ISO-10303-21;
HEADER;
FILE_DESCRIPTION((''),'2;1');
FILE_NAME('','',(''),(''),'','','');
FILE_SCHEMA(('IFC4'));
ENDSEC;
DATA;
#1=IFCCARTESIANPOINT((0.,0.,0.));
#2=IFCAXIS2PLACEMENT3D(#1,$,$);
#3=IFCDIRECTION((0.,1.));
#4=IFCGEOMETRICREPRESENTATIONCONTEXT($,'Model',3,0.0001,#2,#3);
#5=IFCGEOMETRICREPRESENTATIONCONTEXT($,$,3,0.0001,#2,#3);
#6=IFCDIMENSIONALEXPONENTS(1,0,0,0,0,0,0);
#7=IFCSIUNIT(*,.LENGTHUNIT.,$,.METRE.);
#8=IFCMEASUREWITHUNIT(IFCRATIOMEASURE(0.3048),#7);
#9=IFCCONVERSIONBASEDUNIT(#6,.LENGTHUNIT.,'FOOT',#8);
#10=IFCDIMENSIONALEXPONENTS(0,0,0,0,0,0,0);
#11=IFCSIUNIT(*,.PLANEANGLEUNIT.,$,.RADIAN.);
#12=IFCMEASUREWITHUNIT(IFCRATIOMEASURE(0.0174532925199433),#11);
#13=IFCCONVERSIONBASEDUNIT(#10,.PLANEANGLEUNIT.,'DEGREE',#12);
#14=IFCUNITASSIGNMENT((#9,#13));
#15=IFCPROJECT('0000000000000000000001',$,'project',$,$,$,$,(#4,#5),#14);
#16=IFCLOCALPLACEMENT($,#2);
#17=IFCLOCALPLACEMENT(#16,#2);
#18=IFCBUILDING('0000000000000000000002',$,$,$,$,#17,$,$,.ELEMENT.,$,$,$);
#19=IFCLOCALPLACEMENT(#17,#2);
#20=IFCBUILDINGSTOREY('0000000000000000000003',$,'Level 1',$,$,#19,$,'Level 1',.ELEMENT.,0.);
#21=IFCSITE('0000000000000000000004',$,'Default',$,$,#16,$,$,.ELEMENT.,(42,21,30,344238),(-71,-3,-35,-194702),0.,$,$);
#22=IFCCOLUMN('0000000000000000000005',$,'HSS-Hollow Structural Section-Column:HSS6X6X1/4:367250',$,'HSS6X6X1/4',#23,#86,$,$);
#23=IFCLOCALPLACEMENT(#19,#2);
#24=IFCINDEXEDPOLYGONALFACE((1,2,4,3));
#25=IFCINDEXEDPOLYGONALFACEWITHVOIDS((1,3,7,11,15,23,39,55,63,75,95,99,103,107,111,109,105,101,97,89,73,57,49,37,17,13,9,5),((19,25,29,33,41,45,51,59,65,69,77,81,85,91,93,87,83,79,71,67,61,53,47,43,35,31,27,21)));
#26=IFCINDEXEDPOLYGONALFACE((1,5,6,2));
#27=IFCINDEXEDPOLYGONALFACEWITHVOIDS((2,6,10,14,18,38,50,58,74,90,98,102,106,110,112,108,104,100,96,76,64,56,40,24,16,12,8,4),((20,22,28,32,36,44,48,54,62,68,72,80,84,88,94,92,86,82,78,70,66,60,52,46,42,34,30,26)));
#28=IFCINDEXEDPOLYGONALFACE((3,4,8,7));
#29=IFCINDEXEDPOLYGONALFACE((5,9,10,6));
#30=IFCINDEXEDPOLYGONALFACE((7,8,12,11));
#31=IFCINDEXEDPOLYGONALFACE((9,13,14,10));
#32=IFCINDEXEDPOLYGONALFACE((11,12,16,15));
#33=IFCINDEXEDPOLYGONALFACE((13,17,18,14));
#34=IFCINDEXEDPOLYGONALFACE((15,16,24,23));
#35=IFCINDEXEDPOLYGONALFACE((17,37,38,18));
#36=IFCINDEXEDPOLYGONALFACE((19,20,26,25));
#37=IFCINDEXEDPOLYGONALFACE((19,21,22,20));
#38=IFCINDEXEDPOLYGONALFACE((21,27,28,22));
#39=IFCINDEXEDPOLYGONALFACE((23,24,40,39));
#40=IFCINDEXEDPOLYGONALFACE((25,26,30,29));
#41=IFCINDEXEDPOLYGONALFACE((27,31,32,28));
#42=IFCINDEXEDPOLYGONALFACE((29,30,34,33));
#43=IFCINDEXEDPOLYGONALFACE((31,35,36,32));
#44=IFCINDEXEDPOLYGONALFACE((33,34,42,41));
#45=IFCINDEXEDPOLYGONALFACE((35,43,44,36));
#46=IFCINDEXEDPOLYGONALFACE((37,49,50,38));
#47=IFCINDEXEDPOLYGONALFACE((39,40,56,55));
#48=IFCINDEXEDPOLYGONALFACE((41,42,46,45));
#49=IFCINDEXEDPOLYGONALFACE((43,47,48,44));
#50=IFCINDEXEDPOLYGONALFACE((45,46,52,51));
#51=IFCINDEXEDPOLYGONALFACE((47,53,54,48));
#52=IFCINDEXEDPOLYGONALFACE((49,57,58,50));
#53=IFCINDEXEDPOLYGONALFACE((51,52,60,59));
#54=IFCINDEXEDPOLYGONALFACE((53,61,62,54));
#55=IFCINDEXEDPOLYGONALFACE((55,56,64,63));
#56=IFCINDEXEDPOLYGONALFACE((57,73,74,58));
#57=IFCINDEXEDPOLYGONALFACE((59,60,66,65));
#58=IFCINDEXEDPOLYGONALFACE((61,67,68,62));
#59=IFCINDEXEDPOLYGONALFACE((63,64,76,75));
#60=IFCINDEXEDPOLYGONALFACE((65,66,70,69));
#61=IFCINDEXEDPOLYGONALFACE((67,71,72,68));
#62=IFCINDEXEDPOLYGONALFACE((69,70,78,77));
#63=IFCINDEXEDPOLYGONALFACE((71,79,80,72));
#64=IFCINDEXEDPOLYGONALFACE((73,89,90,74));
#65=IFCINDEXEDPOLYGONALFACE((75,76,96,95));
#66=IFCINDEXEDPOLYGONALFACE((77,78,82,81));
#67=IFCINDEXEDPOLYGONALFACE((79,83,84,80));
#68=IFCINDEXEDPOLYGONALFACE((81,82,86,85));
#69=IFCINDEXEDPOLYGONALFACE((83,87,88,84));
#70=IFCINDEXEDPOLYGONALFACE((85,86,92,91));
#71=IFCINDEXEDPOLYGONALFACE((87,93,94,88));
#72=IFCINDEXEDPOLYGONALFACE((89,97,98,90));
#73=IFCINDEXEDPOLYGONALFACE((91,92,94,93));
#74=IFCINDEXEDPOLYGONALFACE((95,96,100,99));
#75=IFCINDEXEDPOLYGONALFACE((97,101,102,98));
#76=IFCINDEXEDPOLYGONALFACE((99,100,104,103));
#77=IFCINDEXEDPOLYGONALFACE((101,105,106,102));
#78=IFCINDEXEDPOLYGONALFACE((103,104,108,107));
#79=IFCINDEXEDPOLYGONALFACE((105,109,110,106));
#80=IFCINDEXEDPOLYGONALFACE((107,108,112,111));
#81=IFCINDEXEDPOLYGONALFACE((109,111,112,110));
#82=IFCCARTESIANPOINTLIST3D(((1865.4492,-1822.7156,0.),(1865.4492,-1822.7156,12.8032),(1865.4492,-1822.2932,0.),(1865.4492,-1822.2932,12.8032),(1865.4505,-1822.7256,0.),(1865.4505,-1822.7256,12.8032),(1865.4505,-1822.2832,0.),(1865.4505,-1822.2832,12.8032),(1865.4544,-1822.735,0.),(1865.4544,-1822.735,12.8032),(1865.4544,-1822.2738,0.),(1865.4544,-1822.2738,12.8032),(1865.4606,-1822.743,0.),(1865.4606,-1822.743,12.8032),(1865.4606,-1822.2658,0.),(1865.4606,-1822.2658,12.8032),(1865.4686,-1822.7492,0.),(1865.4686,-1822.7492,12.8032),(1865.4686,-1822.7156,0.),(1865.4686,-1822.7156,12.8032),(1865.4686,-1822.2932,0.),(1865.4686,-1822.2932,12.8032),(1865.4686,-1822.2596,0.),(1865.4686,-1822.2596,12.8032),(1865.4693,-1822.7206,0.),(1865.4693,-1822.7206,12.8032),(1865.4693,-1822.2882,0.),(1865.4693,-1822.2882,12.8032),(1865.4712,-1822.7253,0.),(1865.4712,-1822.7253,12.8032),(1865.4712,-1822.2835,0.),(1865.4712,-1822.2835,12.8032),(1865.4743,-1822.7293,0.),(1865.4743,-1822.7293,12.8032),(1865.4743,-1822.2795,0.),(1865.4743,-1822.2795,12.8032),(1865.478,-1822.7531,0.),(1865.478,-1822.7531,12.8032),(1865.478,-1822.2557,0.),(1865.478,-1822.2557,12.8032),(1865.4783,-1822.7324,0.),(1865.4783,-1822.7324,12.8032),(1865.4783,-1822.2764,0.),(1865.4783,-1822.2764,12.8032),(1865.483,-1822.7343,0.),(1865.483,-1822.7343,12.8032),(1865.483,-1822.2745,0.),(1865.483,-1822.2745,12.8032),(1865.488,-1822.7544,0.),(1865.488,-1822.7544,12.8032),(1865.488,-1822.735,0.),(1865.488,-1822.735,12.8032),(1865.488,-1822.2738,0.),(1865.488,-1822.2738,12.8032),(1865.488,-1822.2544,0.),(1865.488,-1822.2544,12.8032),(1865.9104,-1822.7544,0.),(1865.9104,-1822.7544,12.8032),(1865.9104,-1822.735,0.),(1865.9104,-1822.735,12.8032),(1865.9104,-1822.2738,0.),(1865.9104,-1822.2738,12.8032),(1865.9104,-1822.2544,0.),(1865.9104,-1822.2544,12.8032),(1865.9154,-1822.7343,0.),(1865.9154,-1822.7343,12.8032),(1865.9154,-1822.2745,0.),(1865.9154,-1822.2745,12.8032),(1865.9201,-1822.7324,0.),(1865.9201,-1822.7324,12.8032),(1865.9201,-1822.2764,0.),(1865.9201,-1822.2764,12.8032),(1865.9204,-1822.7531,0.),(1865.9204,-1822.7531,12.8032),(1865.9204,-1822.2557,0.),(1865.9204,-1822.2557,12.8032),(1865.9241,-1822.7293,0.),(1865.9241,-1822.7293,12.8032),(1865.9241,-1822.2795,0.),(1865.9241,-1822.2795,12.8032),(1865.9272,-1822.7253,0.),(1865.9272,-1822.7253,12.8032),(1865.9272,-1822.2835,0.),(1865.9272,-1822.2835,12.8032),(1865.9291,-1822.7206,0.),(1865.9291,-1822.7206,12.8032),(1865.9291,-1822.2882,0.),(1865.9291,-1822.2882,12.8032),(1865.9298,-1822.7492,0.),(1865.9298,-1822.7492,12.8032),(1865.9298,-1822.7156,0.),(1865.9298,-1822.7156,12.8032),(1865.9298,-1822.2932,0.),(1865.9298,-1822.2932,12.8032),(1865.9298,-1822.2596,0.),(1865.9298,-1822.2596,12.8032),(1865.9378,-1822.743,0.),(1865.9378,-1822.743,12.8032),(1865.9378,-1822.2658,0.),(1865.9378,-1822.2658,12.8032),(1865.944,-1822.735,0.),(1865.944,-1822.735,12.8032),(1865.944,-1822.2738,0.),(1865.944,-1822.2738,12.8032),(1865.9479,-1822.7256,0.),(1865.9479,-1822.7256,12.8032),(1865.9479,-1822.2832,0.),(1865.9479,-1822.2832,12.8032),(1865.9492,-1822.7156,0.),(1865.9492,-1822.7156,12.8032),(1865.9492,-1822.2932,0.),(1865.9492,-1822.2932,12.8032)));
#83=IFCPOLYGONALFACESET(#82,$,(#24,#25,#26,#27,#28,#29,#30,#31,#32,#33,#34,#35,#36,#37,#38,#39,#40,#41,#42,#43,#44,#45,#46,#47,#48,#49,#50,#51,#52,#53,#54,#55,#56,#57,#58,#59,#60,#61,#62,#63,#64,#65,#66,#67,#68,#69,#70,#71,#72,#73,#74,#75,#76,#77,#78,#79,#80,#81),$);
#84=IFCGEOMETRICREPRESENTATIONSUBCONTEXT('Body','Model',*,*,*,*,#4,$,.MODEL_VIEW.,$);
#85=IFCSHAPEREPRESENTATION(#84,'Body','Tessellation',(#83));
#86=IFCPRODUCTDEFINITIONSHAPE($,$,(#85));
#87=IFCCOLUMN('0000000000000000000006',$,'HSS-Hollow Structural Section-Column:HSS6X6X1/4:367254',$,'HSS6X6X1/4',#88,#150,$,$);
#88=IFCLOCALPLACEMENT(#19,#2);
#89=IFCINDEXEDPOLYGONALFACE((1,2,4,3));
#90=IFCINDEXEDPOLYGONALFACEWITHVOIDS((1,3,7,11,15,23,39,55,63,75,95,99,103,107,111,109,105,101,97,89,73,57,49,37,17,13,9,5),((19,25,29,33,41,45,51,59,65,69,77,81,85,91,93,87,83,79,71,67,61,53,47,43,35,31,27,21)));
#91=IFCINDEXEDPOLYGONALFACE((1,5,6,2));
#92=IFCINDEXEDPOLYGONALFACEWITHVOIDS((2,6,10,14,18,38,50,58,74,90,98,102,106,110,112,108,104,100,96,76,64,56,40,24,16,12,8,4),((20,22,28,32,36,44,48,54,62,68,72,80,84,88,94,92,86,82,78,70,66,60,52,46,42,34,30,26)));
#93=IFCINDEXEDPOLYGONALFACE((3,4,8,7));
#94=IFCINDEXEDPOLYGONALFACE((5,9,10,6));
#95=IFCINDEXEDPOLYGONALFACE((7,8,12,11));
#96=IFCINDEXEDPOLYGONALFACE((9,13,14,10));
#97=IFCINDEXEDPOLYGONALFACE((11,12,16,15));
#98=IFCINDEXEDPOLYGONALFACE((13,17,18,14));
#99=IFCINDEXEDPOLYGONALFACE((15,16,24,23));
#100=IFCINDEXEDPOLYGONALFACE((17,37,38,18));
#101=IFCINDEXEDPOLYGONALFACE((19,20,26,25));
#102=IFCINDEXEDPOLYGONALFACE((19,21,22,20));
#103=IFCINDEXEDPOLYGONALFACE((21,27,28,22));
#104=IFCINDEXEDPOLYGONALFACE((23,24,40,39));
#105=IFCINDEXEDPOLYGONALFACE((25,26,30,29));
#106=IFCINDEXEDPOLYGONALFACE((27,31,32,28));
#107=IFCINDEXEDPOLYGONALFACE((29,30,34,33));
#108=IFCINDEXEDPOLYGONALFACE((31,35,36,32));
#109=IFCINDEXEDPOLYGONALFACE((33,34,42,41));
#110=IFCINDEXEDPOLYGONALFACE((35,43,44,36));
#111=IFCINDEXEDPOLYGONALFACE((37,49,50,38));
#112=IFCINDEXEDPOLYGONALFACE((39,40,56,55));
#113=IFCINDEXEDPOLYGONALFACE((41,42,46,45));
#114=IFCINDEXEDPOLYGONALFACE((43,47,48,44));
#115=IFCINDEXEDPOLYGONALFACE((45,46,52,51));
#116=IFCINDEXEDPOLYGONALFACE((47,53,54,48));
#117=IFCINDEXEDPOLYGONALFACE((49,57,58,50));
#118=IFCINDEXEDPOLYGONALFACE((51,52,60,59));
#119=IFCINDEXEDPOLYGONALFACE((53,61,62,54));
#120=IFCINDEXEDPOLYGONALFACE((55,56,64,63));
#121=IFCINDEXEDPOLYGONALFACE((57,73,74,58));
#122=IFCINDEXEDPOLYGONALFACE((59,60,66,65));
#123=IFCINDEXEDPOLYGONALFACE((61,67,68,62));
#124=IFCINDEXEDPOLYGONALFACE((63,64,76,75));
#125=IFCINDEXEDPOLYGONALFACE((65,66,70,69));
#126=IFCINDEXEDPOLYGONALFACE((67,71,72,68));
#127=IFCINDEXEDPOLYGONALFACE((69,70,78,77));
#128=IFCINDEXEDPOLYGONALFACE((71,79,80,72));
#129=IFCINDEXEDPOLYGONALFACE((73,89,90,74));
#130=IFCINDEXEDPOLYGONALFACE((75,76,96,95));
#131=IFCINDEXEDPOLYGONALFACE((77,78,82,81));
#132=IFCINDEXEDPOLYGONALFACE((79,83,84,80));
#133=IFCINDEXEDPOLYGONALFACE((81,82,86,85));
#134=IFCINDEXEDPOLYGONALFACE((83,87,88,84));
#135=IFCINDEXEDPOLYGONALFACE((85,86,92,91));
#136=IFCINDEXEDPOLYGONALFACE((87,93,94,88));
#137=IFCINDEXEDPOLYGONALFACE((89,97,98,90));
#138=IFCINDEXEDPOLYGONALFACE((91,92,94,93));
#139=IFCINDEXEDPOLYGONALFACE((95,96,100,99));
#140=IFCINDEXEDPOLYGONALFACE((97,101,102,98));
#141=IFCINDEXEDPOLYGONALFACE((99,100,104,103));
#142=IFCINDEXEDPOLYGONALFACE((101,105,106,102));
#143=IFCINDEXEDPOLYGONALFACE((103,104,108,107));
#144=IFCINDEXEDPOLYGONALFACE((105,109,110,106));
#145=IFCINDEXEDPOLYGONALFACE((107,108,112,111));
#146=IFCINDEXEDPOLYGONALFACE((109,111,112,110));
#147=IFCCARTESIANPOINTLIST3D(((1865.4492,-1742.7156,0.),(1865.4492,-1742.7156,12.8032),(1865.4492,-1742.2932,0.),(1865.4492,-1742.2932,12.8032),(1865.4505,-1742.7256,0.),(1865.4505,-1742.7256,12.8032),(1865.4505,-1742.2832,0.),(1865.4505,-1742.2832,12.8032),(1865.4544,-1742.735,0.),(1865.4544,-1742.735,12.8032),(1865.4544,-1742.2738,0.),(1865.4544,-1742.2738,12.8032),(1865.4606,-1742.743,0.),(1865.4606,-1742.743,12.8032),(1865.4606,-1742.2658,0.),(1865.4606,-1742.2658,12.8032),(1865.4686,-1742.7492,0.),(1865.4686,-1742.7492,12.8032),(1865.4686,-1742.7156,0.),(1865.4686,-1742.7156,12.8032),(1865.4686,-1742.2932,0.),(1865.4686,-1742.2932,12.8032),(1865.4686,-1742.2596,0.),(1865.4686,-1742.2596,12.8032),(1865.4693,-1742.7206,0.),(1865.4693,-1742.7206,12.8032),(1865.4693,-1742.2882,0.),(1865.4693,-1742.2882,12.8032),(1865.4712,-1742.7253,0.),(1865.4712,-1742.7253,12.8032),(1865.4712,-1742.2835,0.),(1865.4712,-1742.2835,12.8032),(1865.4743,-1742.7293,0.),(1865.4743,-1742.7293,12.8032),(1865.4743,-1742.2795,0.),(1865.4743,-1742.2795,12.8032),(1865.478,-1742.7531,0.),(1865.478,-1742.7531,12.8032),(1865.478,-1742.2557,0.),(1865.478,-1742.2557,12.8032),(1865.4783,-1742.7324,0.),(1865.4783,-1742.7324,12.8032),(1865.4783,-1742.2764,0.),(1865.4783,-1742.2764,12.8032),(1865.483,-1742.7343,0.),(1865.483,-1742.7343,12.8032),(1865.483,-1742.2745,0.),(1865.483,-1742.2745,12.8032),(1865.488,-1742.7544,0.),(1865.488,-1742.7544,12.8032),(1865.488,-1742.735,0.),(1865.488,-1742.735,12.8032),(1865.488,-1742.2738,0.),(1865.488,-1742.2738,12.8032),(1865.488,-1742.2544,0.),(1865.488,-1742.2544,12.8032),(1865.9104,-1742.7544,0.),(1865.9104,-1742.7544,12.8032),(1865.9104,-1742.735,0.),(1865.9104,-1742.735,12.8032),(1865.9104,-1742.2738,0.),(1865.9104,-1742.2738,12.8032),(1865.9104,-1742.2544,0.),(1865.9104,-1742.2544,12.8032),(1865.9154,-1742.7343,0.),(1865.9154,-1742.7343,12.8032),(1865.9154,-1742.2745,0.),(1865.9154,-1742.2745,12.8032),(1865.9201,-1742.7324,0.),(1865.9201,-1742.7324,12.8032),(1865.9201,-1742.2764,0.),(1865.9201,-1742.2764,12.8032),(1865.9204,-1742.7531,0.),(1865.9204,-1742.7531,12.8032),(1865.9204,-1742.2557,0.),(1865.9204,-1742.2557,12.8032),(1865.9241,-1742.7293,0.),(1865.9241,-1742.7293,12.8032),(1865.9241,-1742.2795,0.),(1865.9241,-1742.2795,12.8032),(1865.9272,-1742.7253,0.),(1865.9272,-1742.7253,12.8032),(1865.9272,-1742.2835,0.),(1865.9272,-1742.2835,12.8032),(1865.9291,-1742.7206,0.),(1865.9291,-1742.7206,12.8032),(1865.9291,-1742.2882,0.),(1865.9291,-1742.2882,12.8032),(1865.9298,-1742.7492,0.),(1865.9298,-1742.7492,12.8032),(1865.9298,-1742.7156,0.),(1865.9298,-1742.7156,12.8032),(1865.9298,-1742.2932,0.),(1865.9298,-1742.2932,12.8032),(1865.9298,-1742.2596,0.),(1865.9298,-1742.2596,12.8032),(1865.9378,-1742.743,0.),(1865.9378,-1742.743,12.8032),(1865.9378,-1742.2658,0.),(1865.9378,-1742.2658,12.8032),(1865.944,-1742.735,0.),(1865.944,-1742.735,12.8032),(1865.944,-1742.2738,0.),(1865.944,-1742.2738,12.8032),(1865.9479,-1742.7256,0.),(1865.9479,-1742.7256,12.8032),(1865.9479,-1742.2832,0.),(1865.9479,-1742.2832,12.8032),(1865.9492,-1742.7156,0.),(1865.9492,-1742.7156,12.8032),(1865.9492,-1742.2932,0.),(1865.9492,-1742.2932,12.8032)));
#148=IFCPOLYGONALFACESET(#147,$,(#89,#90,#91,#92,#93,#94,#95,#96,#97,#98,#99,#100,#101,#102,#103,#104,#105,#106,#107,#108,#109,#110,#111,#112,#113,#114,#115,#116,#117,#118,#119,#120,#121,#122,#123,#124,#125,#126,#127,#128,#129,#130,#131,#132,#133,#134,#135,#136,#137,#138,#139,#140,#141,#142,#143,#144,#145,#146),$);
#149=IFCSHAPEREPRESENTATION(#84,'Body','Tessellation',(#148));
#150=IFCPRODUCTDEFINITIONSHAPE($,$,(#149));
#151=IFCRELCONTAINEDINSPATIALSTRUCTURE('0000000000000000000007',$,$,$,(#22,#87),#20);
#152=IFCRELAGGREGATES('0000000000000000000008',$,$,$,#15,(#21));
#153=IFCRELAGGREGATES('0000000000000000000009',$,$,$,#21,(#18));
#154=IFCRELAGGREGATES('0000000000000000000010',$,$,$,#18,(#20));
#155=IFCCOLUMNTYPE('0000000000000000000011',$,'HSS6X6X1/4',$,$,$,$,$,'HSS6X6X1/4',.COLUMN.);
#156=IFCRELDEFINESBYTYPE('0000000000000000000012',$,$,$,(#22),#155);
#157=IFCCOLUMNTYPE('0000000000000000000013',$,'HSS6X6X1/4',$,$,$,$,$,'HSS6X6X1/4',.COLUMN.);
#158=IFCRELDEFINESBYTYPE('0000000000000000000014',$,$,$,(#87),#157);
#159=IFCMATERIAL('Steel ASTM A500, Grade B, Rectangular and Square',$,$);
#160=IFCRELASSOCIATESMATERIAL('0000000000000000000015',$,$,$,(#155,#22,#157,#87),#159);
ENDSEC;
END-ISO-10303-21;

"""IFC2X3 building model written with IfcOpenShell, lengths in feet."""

from ifc_helpers import new_model, entity, si_unit, converted_unit, direction, frame, frame_2d, origin, place, context, subcontext, project, spatial, polyline, circle_curve, parameter, trimmed, segment, composite_curve, outline, extrude, source, transform, mapped, material, type_object, type_shapes, element, save


model = new_model("IFC2X3")

# Units and contexts
model_context = context("Model", 3, precision=0.0001, world=origin(), true_north=direction((0.0, 1.0)))
context_of_model = context(None, 3, precision=0.0001, world=origin(), true_north=direction((0.0, 1.0)))
body_context = subcontext(model_context, "Body", "Model", "MODEL_VIEW")
ifc_project = project(units=[converted_unit("LENGTHUNIT", "FOOT", entity("IfcRatioMeasure", 0.3048), si_unit("LENGTHUNIT", "METRE"), dimensions=[1, 0, 0, 0, 0, 0, 0]), converted_unit("PLANEANGLEUNIT", "DEGREE", entity("IfcRatioMeasure", 0.0174532925199433), si_unit("PLANEANGLEUNIT", "RADIAN"), dimensions=[0, 0, 0, 0, 0, 0, 0])], contexts=[model_context, context_of_model])

# Site, building, storey
site_placement = place(None, origin())
site = spatial("IfcSite", under=ifc_project, at=site_placement, Name="Default", CompositionType="ELEMENT", RefLatitude=(42, 21, 30, 344238), RefLongitude=(-71, -3, -35, -194702), RefElevation=0.0)
building_placement = place(site_placement, origin())
building = spatial("IfcBuilding", under=site, at=building_placement, CompositionType="ELEMENT")
storey_placement = place(building_placement, origin())
storey = spatial("IfcBuildingStorey", under=building, at=storey_placement, Name="Level 1", LongName="Level 1", CompositionType="ELEMENT", Elevation=0.0)

# Columns
ifc_material_1 = material(Name="Steel ASTM A500, Grade B, Rectangular and Square")
column_type_1 = type_object("IfcColumnType", Name="HSS6X6X1/4", ElementType="HSS6X6X1/4", PredefinedType="COLUMN", material=ifc_material_1)
shared_shape_1 = source(origin(), body_context, "Body", "SweptSolid", [
    extrude(outline(composite_curve([segment(polyline([(-0.2112, -0.25), (0.2112, -0.25)]), True, "CONTINUOUS"), segment(trimmed(circle_curve(frame_2d((0.2112, -0.2112), x_axis=(-1.0, 0.0)), 0.0388), [parameter(90.0)], [parameter(180.0)], True, "PARAMETER"), True, "CONTINUOUS"), segment(polyline([(0.25, -0.2112), (0.25, 0.2112)]), True, "CONTINUOUS"), segment(trimmed(circle_curve(frame_2d((0.2112, 0.2112), x_axis=(-1.0, 0.0)), 0.0388), [parameter(180.0)], [parameter(270.0)], True, "PARAMETER"), True, "CONTINUOUS"), segment(polyline([(0.2112, 0.25), (-0.2112, 0.25)]), True, "CONTINUOUS"), segment(trimmed(circle_curve(frame_2d((-0.2112, 0.2112), x_axis=(-1.0, 0.0)), 0.0388), [parameter(270.0)], [parameter(360.0)], True, "PARAMETER"), True, "CONTINUOUS"), segment(polyline([(-0.25, 0.2112), (-0.25, -0.2112)]), True, "CONTINUOUS"), segment(trimmed(circle_curve(frame_2d((-0.2112, -0.2112), x_axis=(-1.0, 0.0)), 0.0388), [parameter(360.0)], [parameter(90.0)], True, "PARAMETER"), True, "CONTINUOUS")], self_intersect=False), holes=[composite_curve([segment(trimmed(circle_curve(frame_2d((-0.2112, -0.2112), x_axis=(-1.0, 0.0)), 0.0194), [parameter(0.0)], [parameter(90.0)], True, "PARAMETER"), False, "CONTINUOUS"), segment(polyline([(-0.2306, -0.2112), (-0.2306, 0.2112)]), True, "CONTINUOUS"), segment(trimmed(circle_curve(frame_2d((-0.2112, 0.2112), x_axis=(-1.0, 0.0)), 0.0194), [parameter(270.0)], [parameter(360.0)], True, "PARAMETER"), False, "CONTINUOUS"), segment(polyline([(-0.2112, 0.2306), (0.2112, 0.2306)]), True, "CONTINUOUS"), segment(trimmed(circle_curve(frame_2d((0.2112, 0.2112), x_axis=(-1.0, 0.0)), 0.0194), [parameter(180.0)], [parameter(270.0)], True, "PARAMETER"), False, "CONTINUOUS"), segment(polyline([(0.2306, 0.2112), (0.2306, -0.2112)]), True, "CONTINUOUS"), segment(trimmed(circle_curve(frame_2d((0.2112, -0.2112), x_axis=(-1.0, 0.0)), 0.0194), [parameter(90.0)], [parameter(180.0)], True, "PARAMETER"), False, "CONTINUOUS"), segment(polyline([(0.2112, -0.2306), (-0.2112, -0.2306)]), True, "CONTINUOUS")], self_intersect=False)]), frame((1865.6992, -1822.5044, 0.0)), (0.0, 0.0, 1.0), 12.8032),
])
type_shapes(column_type_1, [shared_shape_1])
column_1_placement = place(storey_placement, origin())
element("IfcColumn", 1, at=column_1_placement, inside=storey, type_object=column_type_1, material=ifc_material_1, Name="HSS-Hollow Structural Section-Column:HSS6X6X1/4:367250", ObjectType="HSS6X6X1/4", context=body_context, shape_type="MappedRepresentation", body=[
    mapped(shared_shape_1, transform((0.0, 0.0, 0.0), scale=1.0)),
])
column_type_2 = type_object("IfcColumnType", Name="HSS6X6X1/4", ElementType="HSS6X6X1/4", PredefinedType="COLUMN", material=ifc_material_1)
shared_shape_2 = source(origin(), body_context, "Body", "SweptSolid", [
    extrude(outline(composite_curve([segment(polyline([(-0.2112, -0.25), (0.2112, -0.25)]), True, "CONTINUOUS"), segment(trimmed(circle_curve(frame_2d((0.2112, -0.2112), x_axis=(-1.0, 0.0)), 0.0388), [parameter(90.0)], [parameter(180.0)], True, "PARAMETER"), True, "CONTINUOUS"), segment(polyline([(0.25, -0.2112), (0.25, 0.2112)]), True, "CONTINUOUS"), segment(trimmed(circle_curve(frame_2d((0.2112, 0.2112), x_axis=(-1.0, 0.0)), 0.0388), [parameter(180.0)], [parameter(270.0)], True, "PARAMETER"), True, "CONTINUOUS"), segment(polyline([(0.2112, 0.25), (-0.2112, 0.25)]), True, "CONTINUOUS"), segment(trimmed(circle_curve(frame_2d((-0.2112, 0.2112), x_axis=(-1.0, 0.0)), 0.0388), [parameter(270.0)], [parameter(360.0)], True, "PARAMETER"), True, "CONTINUOUS"), segment(polyline([(-0.25, 0.2112), (-0.25, -0.2112)]), True, "CONTINUOUS"), segment(trimmed(circle_curve(frame_2d((-0.2112, -0.2112), x_axis=(-1.0, 0.0)), 0.0388), [parameter(360.0)], [parameter(90.0)], True, "PARAMETER"), True, "CONTINUOUS")], self_intersect=False), holes=[composite_curve([segment(trimmed(circle_curve(frame_2d((-0.2112, -0.2112), x_axis=(-1.0, 0.0)), 0.0194), [parameter(0.0)], [parameter(90.0)], True, "PARAMETER"), False, "CONTINUOUS"), segment(polyline([(-0.2306, -0.2112), (-0.2306, 0.2112)]), True, "CONTINUOUS"), segment(trimmed(circle_curve(frame_2d((-0.2112, 0.2112), x_axis=(-1.0, 0.0)), 0.0194), [parameter(270.0)], [parameter(360.0)], True, "PARAMETER"), False, "CONTINUOUS"), segment(polyline([(-0.2112, 0.2306), (0.2112, 0.2306)]), True, "CONTINUOUS"), segment(trimmed(circle_curve(frame_2d((0.2112, 0.2112), x_axis=(-1.0, 0.0)), 0.0194), [parameter(180.0)], [parameter(270.0)], True, "PARAMETER"), False, "CONTINUOUS"), segment(polyline([(0.2306, 0.2112), (0.2306, -0.2112)]), True, "CONTINUOUS"), segment(trimmed(circle_curve(frame_2d((0.2112, -0.2112), x_axis=(-1.0, 0.0)), 0.0194), [parameter(90.0)], [parameter(180.0)], True, "PARAMETER"), False, "CONTINUOUS"), segment(polyline([(0.2112, -0.2306), (-0.2112, -0.2306)]), True, "CONTINUOUS")], self_intersect=False)]), frame((1865.6992, -1742.5044, 0.0)), (0.0, 0.0, 1.0), 12.8032),
])
type_shapes(column_type_2, [shared_shape_2])
column_2_placement = place(storey_placement, origin())
element("IfcColumn", 2, at=column_2_placement, inside=storey, type_object=column_type_2, material=ifc_material_1, Name="HSS-Hollow Structural Section-Column:HSS6X6X1/4:367254", ObjectType="HSS6X6X1/4", context=body_context, shape_type="MappedRepresentation", body=[
    mapped(shared_shape_2, transform((0.0, 0.0, 0.0), scale=1.0)),
])

save(model, "model.ifc")
